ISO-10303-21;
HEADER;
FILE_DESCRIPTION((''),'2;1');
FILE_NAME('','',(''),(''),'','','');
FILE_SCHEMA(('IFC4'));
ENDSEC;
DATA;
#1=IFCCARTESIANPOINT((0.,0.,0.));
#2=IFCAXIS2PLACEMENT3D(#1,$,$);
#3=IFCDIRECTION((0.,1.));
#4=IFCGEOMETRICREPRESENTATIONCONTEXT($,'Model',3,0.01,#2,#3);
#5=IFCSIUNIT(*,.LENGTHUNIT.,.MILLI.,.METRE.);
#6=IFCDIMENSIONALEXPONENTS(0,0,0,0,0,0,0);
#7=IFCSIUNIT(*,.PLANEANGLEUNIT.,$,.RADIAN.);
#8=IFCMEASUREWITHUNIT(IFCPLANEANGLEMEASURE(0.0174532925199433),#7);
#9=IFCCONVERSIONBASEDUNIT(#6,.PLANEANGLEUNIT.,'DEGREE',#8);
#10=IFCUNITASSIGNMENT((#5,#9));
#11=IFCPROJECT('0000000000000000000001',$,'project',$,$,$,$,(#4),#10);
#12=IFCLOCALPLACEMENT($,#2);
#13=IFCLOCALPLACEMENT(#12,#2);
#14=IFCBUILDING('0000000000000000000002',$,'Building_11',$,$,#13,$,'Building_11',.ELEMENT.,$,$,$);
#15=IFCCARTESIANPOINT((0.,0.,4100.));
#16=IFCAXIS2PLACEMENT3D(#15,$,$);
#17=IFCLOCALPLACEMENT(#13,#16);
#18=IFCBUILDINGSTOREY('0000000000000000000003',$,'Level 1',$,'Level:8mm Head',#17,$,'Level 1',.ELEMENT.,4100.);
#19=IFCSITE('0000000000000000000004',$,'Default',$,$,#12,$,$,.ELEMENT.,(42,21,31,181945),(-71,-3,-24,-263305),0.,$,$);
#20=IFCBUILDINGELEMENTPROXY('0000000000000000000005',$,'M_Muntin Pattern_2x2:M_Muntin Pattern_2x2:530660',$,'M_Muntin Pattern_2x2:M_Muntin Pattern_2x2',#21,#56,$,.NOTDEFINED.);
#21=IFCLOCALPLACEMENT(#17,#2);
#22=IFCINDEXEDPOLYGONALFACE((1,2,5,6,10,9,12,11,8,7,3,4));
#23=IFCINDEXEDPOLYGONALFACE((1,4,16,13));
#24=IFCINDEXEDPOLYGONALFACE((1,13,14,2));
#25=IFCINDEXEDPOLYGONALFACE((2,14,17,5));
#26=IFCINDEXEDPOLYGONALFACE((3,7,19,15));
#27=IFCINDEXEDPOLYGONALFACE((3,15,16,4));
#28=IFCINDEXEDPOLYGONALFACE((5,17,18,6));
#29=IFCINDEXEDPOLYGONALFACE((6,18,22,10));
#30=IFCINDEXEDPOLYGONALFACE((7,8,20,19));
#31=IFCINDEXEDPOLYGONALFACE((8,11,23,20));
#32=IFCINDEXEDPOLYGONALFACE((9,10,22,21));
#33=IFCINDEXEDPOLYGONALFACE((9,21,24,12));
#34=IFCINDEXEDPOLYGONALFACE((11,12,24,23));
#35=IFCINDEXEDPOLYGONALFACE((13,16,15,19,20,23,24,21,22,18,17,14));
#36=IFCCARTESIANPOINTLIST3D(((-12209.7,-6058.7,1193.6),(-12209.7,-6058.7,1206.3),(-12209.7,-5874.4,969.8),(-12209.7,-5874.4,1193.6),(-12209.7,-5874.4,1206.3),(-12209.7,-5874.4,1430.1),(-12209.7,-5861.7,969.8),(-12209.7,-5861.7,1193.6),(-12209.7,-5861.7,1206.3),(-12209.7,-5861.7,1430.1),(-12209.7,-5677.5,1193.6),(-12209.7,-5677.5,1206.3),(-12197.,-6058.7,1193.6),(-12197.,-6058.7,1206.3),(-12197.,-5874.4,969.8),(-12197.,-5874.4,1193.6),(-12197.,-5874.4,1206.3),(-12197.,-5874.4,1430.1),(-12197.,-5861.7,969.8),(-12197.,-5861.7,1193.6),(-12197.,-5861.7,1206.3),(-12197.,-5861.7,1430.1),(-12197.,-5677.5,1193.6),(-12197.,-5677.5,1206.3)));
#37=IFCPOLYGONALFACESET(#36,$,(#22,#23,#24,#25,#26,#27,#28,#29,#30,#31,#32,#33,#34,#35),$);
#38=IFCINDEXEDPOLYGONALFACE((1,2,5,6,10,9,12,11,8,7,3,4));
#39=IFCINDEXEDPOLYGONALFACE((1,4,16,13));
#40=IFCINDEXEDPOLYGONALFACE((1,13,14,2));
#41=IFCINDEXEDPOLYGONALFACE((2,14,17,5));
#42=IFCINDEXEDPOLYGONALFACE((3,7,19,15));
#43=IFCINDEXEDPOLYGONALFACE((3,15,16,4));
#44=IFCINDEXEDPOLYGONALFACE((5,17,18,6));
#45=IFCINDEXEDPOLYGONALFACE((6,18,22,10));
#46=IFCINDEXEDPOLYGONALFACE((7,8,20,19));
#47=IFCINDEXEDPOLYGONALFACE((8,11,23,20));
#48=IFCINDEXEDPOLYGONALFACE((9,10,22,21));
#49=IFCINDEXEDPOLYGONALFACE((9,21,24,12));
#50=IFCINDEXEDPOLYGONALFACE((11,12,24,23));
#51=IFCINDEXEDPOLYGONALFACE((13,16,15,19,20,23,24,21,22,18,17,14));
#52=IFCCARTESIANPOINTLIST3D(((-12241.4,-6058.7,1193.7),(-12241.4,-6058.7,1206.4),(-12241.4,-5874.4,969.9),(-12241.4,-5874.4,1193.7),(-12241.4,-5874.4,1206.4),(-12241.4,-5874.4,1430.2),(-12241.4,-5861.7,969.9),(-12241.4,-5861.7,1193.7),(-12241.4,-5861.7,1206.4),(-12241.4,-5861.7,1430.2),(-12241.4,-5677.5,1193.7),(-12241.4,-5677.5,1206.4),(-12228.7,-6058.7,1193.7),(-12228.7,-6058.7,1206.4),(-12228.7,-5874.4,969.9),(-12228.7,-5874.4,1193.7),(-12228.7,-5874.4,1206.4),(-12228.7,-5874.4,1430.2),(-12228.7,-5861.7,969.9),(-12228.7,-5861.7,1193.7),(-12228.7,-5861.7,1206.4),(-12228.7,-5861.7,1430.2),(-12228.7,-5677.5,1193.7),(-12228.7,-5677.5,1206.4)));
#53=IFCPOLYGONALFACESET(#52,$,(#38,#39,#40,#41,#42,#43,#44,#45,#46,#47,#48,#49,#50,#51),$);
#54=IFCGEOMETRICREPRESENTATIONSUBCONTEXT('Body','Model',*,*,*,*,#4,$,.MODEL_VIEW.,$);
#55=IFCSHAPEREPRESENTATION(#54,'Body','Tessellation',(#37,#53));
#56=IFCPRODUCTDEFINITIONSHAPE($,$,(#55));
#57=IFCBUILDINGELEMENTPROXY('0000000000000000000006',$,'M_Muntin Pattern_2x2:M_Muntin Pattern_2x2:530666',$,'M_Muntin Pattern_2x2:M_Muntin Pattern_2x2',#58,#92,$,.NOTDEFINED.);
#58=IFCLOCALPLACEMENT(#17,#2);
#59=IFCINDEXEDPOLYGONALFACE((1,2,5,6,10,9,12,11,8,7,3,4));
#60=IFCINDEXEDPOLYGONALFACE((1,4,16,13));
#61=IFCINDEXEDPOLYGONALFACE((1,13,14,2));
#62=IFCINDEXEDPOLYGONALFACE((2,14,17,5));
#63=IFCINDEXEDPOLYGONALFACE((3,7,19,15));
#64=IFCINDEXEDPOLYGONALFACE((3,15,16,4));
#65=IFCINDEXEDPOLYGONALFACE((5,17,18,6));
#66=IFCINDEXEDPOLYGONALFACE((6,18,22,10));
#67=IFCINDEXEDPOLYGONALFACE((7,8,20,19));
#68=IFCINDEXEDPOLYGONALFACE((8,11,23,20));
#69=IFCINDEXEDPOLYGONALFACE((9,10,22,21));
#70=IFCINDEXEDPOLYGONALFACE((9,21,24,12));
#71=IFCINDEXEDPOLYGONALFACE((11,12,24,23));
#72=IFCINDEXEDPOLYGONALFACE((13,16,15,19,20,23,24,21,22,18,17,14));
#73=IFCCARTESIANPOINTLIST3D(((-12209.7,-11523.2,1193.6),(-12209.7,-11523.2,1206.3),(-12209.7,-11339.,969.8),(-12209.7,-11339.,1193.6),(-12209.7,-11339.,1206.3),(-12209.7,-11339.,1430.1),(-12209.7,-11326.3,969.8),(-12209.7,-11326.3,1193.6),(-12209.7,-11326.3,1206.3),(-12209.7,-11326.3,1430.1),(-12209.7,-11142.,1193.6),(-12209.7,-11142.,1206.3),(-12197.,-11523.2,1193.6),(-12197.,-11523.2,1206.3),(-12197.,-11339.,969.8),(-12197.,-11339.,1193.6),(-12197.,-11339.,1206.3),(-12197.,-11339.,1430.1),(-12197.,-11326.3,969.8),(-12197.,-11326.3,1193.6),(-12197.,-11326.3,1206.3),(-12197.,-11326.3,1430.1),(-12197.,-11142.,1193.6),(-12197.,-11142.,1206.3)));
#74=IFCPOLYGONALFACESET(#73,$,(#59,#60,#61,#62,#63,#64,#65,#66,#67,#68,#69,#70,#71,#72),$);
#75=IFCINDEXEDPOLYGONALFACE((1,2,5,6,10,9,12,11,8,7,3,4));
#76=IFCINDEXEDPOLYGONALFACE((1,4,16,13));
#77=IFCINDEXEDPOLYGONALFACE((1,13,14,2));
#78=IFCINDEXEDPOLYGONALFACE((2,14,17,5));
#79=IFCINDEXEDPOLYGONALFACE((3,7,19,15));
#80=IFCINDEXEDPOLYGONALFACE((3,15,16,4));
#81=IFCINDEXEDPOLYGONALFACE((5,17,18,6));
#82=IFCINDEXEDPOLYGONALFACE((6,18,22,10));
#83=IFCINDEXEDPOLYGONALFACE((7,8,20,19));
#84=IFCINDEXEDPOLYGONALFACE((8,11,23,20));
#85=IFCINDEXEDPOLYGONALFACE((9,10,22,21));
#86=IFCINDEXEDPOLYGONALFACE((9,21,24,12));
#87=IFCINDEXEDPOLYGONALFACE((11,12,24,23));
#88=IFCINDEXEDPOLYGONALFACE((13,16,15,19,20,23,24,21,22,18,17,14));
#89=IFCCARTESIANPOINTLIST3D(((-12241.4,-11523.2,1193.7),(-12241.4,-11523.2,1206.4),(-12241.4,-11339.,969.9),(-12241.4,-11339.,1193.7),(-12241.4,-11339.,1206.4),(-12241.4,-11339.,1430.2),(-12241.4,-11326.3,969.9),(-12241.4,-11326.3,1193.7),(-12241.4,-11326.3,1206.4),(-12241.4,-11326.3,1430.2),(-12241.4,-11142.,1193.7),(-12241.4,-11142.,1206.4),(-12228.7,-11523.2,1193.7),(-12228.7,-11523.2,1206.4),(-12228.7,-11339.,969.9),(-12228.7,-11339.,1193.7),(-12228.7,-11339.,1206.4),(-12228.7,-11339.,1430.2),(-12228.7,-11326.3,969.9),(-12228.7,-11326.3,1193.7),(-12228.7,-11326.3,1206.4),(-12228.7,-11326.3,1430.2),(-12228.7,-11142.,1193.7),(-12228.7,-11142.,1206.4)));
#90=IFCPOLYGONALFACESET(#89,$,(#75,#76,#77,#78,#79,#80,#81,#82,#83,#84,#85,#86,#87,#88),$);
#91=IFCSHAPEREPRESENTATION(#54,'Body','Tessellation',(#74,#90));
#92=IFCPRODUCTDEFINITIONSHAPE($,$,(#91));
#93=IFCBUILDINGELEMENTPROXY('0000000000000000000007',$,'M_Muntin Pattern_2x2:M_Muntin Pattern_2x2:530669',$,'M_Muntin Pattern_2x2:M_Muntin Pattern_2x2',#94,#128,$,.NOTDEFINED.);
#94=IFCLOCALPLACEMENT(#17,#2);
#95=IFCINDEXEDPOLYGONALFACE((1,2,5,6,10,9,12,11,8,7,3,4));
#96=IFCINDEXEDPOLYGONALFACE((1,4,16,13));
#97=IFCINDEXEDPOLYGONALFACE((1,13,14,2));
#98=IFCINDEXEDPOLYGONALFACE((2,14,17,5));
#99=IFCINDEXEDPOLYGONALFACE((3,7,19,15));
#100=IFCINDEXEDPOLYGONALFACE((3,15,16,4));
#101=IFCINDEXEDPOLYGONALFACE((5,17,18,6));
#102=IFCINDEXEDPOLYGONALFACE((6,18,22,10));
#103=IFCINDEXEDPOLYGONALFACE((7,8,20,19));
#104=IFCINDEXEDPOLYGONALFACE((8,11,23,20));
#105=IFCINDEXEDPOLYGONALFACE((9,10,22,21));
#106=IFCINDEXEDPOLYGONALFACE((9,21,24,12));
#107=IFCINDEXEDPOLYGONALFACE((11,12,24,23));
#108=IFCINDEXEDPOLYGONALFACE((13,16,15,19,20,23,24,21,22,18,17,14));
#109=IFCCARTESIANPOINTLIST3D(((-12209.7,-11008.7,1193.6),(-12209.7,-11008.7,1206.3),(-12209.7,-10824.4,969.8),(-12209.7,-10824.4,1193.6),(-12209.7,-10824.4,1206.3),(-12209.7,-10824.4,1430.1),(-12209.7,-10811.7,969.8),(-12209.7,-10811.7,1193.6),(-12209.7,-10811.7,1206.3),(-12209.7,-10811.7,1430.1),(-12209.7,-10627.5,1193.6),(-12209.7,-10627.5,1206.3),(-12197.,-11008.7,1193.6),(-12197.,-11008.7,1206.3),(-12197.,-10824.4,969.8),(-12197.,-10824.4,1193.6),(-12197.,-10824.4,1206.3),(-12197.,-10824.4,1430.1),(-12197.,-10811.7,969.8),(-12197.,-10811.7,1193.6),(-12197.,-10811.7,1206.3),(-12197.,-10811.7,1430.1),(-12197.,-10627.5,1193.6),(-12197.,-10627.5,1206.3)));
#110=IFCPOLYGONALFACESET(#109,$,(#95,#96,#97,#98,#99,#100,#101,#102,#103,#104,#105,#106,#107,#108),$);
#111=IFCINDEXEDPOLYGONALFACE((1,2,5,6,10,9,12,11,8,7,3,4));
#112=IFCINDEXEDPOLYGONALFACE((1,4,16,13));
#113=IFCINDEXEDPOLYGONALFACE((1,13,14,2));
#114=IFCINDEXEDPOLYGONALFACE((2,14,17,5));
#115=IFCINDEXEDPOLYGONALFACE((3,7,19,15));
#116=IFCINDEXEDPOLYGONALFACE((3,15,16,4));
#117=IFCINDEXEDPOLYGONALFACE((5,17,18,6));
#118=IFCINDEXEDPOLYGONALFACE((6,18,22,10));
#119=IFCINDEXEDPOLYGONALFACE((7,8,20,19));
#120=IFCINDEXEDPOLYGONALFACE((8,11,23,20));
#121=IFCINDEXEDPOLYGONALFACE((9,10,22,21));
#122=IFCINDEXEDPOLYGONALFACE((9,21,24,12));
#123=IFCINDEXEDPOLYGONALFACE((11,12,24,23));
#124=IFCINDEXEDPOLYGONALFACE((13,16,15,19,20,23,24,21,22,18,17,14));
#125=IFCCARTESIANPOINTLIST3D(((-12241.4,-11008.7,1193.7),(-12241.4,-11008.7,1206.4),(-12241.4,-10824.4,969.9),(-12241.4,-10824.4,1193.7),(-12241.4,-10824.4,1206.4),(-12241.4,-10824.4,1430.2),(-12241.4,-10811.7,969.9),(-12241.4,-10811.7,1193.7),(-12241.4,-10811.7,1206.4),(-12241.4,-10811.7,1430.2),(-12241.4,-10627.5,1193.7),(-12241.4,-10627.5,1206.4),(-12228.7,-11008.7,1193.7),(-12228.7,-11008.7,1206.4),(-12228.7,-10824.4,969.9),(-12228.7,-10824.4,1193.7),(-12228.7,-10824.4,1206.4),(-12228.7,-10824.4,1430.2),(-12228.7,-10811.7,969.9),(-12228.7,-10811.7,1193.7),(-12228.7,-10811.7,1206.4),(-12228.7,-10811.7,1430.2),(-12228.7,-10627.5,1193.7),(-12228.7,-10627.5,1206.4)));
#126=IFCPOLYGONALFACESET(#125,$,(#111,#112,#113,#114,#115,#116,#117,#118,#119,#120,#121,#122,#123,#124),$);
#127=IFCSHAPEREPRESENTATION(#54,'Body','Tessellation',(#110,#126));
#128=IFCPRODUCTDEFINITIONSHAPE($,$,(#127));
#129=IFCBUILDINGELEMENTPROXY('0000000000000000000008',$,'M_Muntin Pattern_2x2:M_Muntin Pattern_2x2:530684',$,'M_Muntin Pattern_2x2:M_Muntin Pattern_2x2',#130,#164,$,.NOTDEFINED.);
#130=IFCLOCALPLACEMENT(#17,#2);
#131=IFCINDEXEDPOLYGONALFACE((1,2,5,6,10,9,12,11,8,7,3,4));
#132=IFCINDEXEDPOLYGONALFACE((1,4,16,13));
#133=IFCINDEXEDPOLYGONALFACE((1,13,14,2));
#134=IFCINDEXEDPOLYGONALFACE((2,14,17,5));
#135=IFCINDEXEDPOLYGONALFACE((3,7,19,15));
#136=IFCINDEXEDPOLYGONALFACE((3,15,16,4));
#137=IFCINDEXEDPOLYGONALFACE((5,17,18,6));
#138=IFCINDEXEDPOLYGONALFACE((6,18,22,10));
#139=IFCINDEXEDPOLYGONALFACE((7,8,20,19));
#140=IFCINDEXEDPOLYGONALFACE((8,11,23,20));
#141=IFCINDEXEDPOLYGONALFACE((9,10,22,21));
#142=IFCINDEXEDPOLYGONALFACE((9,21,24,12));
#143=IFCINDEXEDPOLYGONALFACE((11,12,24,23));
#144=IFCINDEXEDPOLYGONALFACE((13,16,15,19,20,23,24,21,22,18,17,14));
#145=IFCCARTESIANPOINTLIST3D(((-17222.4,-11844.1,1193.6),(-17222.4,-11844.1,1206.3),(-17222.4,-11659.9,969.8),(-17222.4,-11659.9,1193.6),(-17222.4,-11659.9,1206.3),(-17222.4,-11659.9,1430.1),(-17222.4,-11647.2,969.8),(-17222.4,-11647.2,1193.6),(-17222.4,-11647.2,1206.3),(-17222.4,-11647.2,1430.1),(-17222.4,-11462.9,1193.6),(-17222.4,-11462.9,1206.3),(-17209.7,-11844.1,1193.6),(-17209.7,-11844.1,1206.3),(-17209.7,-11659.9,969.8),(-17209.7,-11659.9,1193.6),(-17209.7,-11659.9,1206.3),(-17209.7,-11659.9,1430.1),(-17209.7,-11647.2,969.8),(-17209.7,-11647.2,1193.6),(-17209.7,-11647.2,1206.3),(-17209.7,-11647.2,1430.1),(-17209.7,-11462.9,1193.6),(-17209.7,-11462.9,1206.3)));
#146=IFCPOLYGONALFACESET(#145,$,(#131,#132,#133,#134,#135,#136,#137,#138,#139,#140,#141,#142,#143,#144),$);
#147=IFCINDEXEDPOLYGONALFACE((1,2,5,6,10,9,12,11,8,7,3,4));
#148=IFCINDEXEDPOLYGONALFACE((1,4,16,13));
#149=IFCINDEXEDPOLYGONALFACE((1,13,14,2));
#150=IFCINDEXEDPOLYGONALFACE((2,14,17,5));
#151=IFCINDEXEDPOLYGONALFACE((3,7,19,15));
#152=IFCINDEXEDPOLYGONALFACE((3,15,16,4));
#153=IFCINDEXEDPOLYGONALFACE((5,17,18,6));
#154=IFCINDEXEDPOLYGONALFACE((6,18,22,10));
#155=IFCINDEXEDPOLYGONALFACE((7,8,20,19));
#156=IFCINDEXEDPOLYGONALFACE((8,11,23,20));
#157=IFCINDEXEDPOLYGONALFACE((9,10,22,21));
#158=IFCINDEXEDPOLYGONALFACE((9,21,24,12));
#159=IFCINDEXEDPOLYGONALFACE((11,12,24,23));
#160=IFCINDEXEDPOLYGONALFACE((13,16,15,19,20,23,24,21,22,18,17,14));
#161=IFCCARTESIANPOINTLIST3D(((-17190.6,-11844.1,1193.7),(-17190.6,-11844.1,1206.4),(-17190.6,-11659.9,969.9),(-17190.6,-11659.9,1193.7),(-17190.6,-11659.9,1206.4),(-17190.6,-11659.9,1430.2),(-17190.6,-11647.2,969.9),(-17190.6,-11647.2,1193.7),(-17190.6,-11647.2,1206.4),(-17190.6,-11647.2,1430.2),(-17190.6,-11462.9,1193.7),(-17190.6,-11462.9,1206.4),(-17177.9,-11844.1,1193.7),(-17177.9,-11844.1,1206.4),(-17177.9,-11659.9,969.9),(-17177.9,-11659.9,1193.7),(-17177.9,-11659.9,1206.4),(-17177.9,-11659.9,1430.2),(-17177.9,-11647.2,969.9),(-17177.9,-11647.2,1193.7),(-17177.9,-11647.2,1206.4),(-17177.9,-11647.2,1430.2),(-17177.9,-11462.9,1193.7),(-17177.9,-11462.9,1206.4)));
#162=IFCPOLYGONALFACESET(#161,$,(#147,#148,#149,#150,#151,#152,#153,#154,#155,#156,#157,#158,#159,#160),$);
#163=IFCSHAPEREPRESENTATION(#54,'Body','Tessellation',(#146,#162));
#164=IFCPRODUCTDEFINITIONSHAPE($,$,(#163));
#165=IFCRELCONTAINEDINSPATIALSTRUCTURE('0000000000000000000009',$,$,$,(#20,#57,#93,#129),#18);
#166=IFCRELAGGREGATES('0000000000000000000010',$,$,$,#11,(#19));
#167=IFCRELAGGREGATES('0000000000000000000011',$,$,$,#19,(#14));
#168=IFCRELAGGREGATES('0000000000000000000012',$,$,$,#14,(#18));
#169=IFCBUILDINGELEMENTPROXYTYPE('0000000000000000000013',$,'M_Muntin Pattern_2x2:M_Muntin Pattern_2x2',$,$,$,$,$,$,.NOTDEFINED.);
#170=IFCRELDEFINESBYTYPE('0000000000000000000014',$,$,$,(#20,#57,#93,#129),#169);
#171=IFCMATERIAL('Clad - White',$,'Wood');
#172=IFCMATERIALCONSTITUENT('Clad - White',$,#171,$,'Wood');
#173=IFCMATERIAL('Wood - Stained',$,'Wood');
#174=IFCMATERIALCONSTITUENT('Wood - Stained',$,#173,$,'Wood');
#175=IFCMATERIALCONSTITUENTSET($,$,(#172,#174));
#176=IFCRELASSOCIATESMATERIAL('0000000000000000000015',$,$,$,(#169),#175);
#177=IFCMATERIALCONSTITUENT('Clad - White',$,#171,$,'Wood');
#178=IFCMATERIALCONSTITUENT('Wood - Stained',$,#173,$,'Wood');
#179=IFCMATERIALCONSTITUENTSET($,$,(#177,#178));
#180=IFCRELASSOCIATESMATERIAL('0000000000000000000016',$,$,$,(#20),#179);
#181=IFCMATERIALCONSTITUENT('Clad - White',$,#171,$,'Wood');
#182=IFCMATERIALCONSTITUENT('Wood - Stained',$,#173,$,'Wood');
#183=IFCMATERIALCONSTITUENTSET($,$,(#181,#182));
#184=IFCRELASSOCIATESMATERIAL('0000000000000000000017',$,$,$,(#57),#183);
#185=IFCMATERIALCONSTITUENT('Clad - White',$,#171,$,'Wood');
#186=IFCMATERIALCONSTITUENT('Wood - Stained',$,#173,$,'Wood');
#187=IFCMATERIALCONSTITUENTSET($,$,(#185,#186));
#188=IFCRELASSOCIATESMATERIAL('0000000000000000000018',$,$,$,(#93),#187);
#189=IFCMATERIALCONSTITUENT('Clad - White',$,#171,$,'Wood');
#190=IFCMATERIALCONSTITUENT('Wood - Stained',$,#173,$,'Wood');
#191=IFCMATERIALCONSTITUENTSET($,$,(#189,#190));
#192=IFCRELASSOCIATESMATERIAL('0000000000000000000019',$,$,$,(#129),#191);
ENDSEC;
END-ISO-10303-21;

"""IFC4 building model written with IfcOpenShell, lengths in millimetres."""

from ifc_helpers import new_model, entity, si_unit, converted_unit, direction, frame, origin, place, context, subcontext, project, spatial, indexed_curve, outline, extrude, source, transform, mapped, material, constituent, constituent_set, type_object, type_shapes, element, save


model = new_model("IFC4")

# Units and contexts
model_context = context("Model", 3, precision=0.01, world=origin(), true_north=direction((0.0, 1.0)))
body_context = subcontext(model_context, "Body", "Model", "MODEL_VIEW")
ifc_project = project(units=[si_unit("LENGTHUNIT", "METRE", prefix="MILLI"), converted_unit("PLANEANGLEUNIT", "DEGREE", entity("IfcPlaneAngleMeasure", 0.0174532925199433), si_unit("PLANEANGLEUNIT", "RADIAN"), dimensions=[0, 0, 0, 0, 0, 0, 0])], contexts=[model_context])

# Site, building, storey
site_placement = place(None, origin())
site = spatial("IfcSite", under=ifc_project, at=site_placement, Name="Default", CompositionType="ELEMENT", RefLatitude=(42, 21, 31, 181945), RefLongitude=(-71, -3, -24, -263305), RefElevation=0.0)
building_placement = place(site_placement, origin())
building = spatial("IfcBuilding", under=site, at=building_placement, Name="Building_11", LongName="Building_11", CompositionType="ELEMENT")
storey_placement = place(building_placement, frame((0.0, 0.0, 4100.0)))
storey = spatial("IfcBuildingStorey", under=building, at=storey_placement, Name="Level 1", ObjectType="Level:8mm Head", LongName="Level 1", CompositionType="ELEMENT", Elevation=4100.0)

# Building element proxies
ifc_material_1 = material(Name="Clad - White", Category="Wood")
ifc_material_2 = material(Name="Wood - Stained", Category="Wood")
ifc_constituent_1 = constituent(ifc_material_1, Name="Clad - White", Category="Wood")
ifc_constituent_2 = constituent(ifc_material_2, Name="Wood - Stained", Category="Wood")
ifc_constituent_set_1 = constituent_set(constituents=[ifc_constituent_1, ifc_constituent_2])
building_element_proxy_type_1 = type_object("IfcBuildingElementProxyType", Name="M_Muntin Pattern_2x2:M_Muntin Pattern_2x2", PredefinedType="NOTDEFINED", material=ifc_constituent_set_1)
shared_shape_1 = source(origin(), body_context, "Body", "SweptSolid", [
    extrude(outline(indexed_curve([(6.4, -6.4), (230.1, -6.4), (230.1, 6.3), (6.4, 6.3), (6.4, 190.6), (-6.3, 190.6), (-6.3, 6.3), (-230.2, 6.3), (-230.2, -6.4), (-6.3, -6.4), (-6.3, -190.6), (6.4, -190.6), (6.4, -6.4)], self_intersect=False)), frame((0.0, -22.2, 230.1), z_axis=(0.0, 1.0, 0.0), x_axis=(0.0, 0.0, 1.0)), (0.0, 0.0, 1.0), 12.7),
    extrude(outline(indexed_curve([(6.4, -6.4), (230.2, -6.4), (230.2, 6.3), (6.4, 6.3), (6.4, 190.6), (-6.3, 190.6), (-6.3, 6.3), (-230.2, 6.3), (-230.2, -6.4), (-6.3, -6.4), (-6.3, -190.6), (6.4, -190.6), (6.4, -6.4)], self_intersect=False)), frame((0.0, 9.5, 230.2), z_axis=(0.0, 1.0, 0.0), x_axis=(0.0, 0.0, 1.0)), (0.0, 0.0, 1.0), 12.7),
])
type_shapes(building_element_proxy_type_1, [shared_shape_1])
ifc_constituent_3 = constituent(ifc_material_1, Name="Clad - White", Category="Wood")
ifc_constituent_4 = constituent(ifc_material_2, Name="Wood - Stained", Category="Wood")
ifc_constituent_set_2 = constituent_set(constituents=[ifc_constituent_3, ifc_constituent_4])
proxy_1_placement = place(storey_placement, frame((-12219.2, -5868.1, 969.9), z_axis=(0.0, 0.0, 1.0), x_axis=(0.0, 1.0, 0.0)))
element("IfcBuildingElementProxy", 1, at=proxy_1_placement, inside=storey, type_object=building_element_proxy_type_1, material=ifc_constituent_set_2, Name="M_Muntin Pattern_2x2:M_Muntin Pattern_2x2:530660", ObjectType="M_Muntin Pattern_2x2:M_Muntin Pattern_2x2", PredefinedType="NOTDEFINED", context=body_context, shape_type="MappedRepresentation", body=[
    mapped(shared_shape_1, transform((0.0, 0.0, 0.0), scale=1.0)),
])
ifc_constituent_5 = constituent(ifc_material_1, Name="Clad - White", Category="Wood")
ifc_constituent_6 = constituent(ifc_material_2, Name="Wood - Stained", Category="Wood")
ifc_constituent_set_3 = constituent_set(constituents=[ifc_constituent_5, ifc_constituent_6])
proxy_2_placement = place(storey_placement, frame((-12219.2, -11332.6, 969.9), z_axis=(0.0, 0.0, 1.0), x_axis=(0.0, 1.0, 0.0)))
element("IfcBuildingElementProxy", 2, at=proxy_2_placement, inside=storey, type_object=building_element_proxy_type_1, material=ifc_constituent_set_3, Name="M_Muntin Pattern_2x2:M_Muntin Pattern_2x2:530666", ObjectType="M_Muntin Pattern_2x2:M_Muntin Pattern_2x2", PredefinedType="NOTDEFINED", context=body_context, shape_type="MappedRepresentation", body=[
    mapped(shared_shape_1, transform((0.0, 0.0, 0.0), scale=1.0)),
])
ifc_constituent_7 = constituent(ifc_material_1, Name="Clad - White", Category="Wood")
ifc_constituent_8 = constituent(ifc_material_2, Name="Wood - Stained", Category="Wood")
ifc_constituent_set_4 = constituent_set(constituents=[ifc_constituent_7, ifc_constituent_8])
proxy_3_placement = place(storey_placement, frame((-12219.2, -10818.1, 969.9), z_axis=(0.0, 0.0, 1.0), x_axis=(0.0, 1.0, 0.0)))
element("IfcBuildingElementProxy", 3, at=proxy_3_placement, inside=storey, type_object=building_element_proxy_type_1, material=ifc_constituent_set_4, Name="M_Muntin Pattern_2x2:M_Muntin Pattern_2x2:530669", ObjectType="M_Muntin Pattern_2x2:M_Muntin Pattern_2x2", PredefinedType="NOTDEFINED", context=body_context, shape_type="MappedRepresentation", body=[
    mapped(shared_shape_1, transform((0.0, 0.0, 0.0), scale=1.0)),
])
ifc_constituent_9 = constituent(ifc_material_1, Name="Clad - White", Category="Wood")
ifc_constituent_10 = constituent(ifc_material_2, Name="Wood - Stained", Category="Wood")
ifc_constituent_set_5 = constituent_set(constituents=[ifc_constituent_9, ifc_constituent_10])
proxy_4_placement = place(storey_placement, frame((-17200.2, -11653.5, 969.9), z_axis=(0.0, 0.0, 1.0), x_axis=(0.0, -1.0, 0.0)))
element("IfcBuildingElementProxy", 4, at=proxy_4_placement, inside=storey, type_object=building_element_proxy_type_1, material=ifc_constituent_set_5, Name="M_Muntin Pattern_2x2:M_Muntin Pattern_2x2:530684", ObjectType="M_Muntin Pattern_2x2:M_Muntin Pattern_2x2", PredefinedType="NOTDEFINED", context=body_context, shape_type="MappedRepresentation", body=[
    mapped(shared_shape_1, transform((0.0, 0.0, 0.0), scale=1.0)),
])

save(model, "model.ifc")
